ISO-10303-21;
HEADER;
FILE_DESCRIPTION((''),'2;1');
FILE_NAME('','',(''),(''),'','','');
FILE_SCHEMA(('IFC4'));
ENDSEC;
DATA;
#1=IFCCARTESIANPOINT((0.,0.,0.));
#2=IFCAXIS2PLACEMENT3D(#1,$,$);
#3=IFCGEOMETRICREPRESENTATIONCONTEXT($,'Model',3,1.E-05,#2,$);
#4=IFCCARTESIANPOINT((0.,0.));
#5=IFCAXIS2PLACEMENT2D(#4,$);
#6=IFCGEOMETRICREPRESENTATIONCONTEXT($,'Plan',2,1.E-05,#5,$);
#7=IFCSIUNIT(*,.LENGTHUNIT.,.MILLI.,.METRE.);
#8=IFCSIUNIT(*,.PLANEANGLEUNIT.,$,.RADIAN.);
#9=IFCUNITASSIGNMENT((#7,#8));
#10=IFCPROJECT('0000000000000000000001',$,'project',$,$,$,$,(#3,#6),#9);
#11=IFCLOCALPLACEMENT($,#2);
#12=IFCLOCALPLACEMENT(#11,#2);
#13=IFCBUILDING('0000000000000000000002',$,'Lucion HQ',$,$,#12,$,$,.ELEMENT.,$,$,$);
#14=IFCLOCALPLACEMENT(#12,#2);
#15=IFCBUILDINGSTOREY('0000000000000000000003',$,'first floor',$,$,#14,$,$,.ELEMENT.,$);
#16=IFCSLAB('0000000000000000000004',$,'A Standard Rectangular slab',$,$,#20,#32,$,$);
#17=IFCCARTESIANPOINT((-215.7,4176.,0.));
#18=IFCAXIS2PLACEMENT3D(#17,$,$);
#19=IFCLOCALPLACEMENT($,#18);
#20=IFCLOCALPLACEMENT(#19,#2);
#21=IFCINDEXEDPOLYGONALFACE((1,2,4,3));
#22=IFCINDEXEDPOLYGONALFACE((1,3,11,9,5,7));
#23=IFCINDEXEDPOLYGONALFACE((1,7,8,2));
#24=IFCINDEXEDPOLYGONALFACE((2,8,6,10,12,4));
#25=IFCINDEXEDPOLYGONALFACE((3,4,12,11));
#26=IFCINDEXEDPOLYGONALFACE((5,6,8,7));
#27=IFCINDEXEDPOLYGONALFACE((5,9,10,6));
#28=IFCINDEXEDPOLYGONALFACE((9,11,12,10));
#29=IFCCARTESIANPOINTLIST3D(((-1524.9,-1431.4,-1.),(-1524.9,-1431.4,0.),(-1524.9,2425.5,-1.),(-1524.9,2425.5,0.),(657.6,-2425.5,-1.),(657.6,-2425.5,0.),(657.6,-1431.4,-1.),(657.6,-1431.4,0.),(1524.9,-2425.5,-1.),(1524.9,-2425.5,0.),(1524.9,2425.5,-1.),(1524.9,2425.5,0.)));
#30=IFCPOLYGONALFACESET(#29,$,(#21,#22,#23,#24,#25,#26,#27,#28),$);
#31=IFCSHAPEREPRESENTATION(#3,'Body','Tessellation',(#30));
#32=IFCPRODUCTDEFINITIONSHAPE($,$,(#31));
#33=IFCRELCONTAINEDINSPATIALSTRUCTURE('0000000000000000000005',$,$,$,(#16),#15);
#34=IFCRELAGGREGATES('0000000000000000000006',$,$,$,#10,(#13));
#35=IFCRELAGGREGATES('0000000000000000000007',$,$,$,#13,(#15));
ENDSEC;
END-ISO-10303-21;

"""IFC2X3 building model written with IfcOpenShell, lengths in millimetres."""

from ifc_helpers import new_model, si_unit, frame, origin, origin_2d, place, context, project, spatial, polyline, outline, extrude, element, save


model = new_model("IFC2X3")

# Units and contexts
model_context = context("Model", 3, precision=1e-05, world=origin())
plan_context = context("Plan", 2, precision=1e-05, world=origin_2d())
ifc_project = project(units=[si_unit("LENGTHUNIT", "METRE", prefix="MILLI"), si_unit("PLANEANGLEUNIT", "RADIAN")], contexts=[model_context, plan_context])

# Building, storey
placement_1 = place(None, origin())
building_placement = place(placement_1, origin())
building = spatial("IfcBuilding", under=ifc_project, at=building_placement, Name="Lucion HQ", CompositionType="ELEMENT")
storey_placement = place(building_placement, origin())
storey = spatial("IfcBuildingStorey", under=building, at=storey_placement, Name="first floor", CompositionType="ELEMENT")

# Slab
placement_2 = place(None, frame((-215.7, 4176.0, 0.0)))
slab_1_placement = place(placement_2, origin())
element("IfcSlab", 1, at=slab_1_placement, inside=storey, Name="A Standard Rectangular slab", context=model_context, shape_type="SweptSolid", body=[
    extrude(outline(polyline([(657.6, -1431.4, 0.0), (-1524.9, -1431.4, 0.0), (-1524.9, 2425.5, 0.0), (1524.9, 2425.5, 0.0), (1524.9, -2425.5, 0.0), (657.6, -2425.5, 0.0), (657.6, -1431.4, 0.0)]), kind="CURVE"), origin(), (0.0, 0.0, -1.0), 1.0),
])

save(model, "model.ifc")
